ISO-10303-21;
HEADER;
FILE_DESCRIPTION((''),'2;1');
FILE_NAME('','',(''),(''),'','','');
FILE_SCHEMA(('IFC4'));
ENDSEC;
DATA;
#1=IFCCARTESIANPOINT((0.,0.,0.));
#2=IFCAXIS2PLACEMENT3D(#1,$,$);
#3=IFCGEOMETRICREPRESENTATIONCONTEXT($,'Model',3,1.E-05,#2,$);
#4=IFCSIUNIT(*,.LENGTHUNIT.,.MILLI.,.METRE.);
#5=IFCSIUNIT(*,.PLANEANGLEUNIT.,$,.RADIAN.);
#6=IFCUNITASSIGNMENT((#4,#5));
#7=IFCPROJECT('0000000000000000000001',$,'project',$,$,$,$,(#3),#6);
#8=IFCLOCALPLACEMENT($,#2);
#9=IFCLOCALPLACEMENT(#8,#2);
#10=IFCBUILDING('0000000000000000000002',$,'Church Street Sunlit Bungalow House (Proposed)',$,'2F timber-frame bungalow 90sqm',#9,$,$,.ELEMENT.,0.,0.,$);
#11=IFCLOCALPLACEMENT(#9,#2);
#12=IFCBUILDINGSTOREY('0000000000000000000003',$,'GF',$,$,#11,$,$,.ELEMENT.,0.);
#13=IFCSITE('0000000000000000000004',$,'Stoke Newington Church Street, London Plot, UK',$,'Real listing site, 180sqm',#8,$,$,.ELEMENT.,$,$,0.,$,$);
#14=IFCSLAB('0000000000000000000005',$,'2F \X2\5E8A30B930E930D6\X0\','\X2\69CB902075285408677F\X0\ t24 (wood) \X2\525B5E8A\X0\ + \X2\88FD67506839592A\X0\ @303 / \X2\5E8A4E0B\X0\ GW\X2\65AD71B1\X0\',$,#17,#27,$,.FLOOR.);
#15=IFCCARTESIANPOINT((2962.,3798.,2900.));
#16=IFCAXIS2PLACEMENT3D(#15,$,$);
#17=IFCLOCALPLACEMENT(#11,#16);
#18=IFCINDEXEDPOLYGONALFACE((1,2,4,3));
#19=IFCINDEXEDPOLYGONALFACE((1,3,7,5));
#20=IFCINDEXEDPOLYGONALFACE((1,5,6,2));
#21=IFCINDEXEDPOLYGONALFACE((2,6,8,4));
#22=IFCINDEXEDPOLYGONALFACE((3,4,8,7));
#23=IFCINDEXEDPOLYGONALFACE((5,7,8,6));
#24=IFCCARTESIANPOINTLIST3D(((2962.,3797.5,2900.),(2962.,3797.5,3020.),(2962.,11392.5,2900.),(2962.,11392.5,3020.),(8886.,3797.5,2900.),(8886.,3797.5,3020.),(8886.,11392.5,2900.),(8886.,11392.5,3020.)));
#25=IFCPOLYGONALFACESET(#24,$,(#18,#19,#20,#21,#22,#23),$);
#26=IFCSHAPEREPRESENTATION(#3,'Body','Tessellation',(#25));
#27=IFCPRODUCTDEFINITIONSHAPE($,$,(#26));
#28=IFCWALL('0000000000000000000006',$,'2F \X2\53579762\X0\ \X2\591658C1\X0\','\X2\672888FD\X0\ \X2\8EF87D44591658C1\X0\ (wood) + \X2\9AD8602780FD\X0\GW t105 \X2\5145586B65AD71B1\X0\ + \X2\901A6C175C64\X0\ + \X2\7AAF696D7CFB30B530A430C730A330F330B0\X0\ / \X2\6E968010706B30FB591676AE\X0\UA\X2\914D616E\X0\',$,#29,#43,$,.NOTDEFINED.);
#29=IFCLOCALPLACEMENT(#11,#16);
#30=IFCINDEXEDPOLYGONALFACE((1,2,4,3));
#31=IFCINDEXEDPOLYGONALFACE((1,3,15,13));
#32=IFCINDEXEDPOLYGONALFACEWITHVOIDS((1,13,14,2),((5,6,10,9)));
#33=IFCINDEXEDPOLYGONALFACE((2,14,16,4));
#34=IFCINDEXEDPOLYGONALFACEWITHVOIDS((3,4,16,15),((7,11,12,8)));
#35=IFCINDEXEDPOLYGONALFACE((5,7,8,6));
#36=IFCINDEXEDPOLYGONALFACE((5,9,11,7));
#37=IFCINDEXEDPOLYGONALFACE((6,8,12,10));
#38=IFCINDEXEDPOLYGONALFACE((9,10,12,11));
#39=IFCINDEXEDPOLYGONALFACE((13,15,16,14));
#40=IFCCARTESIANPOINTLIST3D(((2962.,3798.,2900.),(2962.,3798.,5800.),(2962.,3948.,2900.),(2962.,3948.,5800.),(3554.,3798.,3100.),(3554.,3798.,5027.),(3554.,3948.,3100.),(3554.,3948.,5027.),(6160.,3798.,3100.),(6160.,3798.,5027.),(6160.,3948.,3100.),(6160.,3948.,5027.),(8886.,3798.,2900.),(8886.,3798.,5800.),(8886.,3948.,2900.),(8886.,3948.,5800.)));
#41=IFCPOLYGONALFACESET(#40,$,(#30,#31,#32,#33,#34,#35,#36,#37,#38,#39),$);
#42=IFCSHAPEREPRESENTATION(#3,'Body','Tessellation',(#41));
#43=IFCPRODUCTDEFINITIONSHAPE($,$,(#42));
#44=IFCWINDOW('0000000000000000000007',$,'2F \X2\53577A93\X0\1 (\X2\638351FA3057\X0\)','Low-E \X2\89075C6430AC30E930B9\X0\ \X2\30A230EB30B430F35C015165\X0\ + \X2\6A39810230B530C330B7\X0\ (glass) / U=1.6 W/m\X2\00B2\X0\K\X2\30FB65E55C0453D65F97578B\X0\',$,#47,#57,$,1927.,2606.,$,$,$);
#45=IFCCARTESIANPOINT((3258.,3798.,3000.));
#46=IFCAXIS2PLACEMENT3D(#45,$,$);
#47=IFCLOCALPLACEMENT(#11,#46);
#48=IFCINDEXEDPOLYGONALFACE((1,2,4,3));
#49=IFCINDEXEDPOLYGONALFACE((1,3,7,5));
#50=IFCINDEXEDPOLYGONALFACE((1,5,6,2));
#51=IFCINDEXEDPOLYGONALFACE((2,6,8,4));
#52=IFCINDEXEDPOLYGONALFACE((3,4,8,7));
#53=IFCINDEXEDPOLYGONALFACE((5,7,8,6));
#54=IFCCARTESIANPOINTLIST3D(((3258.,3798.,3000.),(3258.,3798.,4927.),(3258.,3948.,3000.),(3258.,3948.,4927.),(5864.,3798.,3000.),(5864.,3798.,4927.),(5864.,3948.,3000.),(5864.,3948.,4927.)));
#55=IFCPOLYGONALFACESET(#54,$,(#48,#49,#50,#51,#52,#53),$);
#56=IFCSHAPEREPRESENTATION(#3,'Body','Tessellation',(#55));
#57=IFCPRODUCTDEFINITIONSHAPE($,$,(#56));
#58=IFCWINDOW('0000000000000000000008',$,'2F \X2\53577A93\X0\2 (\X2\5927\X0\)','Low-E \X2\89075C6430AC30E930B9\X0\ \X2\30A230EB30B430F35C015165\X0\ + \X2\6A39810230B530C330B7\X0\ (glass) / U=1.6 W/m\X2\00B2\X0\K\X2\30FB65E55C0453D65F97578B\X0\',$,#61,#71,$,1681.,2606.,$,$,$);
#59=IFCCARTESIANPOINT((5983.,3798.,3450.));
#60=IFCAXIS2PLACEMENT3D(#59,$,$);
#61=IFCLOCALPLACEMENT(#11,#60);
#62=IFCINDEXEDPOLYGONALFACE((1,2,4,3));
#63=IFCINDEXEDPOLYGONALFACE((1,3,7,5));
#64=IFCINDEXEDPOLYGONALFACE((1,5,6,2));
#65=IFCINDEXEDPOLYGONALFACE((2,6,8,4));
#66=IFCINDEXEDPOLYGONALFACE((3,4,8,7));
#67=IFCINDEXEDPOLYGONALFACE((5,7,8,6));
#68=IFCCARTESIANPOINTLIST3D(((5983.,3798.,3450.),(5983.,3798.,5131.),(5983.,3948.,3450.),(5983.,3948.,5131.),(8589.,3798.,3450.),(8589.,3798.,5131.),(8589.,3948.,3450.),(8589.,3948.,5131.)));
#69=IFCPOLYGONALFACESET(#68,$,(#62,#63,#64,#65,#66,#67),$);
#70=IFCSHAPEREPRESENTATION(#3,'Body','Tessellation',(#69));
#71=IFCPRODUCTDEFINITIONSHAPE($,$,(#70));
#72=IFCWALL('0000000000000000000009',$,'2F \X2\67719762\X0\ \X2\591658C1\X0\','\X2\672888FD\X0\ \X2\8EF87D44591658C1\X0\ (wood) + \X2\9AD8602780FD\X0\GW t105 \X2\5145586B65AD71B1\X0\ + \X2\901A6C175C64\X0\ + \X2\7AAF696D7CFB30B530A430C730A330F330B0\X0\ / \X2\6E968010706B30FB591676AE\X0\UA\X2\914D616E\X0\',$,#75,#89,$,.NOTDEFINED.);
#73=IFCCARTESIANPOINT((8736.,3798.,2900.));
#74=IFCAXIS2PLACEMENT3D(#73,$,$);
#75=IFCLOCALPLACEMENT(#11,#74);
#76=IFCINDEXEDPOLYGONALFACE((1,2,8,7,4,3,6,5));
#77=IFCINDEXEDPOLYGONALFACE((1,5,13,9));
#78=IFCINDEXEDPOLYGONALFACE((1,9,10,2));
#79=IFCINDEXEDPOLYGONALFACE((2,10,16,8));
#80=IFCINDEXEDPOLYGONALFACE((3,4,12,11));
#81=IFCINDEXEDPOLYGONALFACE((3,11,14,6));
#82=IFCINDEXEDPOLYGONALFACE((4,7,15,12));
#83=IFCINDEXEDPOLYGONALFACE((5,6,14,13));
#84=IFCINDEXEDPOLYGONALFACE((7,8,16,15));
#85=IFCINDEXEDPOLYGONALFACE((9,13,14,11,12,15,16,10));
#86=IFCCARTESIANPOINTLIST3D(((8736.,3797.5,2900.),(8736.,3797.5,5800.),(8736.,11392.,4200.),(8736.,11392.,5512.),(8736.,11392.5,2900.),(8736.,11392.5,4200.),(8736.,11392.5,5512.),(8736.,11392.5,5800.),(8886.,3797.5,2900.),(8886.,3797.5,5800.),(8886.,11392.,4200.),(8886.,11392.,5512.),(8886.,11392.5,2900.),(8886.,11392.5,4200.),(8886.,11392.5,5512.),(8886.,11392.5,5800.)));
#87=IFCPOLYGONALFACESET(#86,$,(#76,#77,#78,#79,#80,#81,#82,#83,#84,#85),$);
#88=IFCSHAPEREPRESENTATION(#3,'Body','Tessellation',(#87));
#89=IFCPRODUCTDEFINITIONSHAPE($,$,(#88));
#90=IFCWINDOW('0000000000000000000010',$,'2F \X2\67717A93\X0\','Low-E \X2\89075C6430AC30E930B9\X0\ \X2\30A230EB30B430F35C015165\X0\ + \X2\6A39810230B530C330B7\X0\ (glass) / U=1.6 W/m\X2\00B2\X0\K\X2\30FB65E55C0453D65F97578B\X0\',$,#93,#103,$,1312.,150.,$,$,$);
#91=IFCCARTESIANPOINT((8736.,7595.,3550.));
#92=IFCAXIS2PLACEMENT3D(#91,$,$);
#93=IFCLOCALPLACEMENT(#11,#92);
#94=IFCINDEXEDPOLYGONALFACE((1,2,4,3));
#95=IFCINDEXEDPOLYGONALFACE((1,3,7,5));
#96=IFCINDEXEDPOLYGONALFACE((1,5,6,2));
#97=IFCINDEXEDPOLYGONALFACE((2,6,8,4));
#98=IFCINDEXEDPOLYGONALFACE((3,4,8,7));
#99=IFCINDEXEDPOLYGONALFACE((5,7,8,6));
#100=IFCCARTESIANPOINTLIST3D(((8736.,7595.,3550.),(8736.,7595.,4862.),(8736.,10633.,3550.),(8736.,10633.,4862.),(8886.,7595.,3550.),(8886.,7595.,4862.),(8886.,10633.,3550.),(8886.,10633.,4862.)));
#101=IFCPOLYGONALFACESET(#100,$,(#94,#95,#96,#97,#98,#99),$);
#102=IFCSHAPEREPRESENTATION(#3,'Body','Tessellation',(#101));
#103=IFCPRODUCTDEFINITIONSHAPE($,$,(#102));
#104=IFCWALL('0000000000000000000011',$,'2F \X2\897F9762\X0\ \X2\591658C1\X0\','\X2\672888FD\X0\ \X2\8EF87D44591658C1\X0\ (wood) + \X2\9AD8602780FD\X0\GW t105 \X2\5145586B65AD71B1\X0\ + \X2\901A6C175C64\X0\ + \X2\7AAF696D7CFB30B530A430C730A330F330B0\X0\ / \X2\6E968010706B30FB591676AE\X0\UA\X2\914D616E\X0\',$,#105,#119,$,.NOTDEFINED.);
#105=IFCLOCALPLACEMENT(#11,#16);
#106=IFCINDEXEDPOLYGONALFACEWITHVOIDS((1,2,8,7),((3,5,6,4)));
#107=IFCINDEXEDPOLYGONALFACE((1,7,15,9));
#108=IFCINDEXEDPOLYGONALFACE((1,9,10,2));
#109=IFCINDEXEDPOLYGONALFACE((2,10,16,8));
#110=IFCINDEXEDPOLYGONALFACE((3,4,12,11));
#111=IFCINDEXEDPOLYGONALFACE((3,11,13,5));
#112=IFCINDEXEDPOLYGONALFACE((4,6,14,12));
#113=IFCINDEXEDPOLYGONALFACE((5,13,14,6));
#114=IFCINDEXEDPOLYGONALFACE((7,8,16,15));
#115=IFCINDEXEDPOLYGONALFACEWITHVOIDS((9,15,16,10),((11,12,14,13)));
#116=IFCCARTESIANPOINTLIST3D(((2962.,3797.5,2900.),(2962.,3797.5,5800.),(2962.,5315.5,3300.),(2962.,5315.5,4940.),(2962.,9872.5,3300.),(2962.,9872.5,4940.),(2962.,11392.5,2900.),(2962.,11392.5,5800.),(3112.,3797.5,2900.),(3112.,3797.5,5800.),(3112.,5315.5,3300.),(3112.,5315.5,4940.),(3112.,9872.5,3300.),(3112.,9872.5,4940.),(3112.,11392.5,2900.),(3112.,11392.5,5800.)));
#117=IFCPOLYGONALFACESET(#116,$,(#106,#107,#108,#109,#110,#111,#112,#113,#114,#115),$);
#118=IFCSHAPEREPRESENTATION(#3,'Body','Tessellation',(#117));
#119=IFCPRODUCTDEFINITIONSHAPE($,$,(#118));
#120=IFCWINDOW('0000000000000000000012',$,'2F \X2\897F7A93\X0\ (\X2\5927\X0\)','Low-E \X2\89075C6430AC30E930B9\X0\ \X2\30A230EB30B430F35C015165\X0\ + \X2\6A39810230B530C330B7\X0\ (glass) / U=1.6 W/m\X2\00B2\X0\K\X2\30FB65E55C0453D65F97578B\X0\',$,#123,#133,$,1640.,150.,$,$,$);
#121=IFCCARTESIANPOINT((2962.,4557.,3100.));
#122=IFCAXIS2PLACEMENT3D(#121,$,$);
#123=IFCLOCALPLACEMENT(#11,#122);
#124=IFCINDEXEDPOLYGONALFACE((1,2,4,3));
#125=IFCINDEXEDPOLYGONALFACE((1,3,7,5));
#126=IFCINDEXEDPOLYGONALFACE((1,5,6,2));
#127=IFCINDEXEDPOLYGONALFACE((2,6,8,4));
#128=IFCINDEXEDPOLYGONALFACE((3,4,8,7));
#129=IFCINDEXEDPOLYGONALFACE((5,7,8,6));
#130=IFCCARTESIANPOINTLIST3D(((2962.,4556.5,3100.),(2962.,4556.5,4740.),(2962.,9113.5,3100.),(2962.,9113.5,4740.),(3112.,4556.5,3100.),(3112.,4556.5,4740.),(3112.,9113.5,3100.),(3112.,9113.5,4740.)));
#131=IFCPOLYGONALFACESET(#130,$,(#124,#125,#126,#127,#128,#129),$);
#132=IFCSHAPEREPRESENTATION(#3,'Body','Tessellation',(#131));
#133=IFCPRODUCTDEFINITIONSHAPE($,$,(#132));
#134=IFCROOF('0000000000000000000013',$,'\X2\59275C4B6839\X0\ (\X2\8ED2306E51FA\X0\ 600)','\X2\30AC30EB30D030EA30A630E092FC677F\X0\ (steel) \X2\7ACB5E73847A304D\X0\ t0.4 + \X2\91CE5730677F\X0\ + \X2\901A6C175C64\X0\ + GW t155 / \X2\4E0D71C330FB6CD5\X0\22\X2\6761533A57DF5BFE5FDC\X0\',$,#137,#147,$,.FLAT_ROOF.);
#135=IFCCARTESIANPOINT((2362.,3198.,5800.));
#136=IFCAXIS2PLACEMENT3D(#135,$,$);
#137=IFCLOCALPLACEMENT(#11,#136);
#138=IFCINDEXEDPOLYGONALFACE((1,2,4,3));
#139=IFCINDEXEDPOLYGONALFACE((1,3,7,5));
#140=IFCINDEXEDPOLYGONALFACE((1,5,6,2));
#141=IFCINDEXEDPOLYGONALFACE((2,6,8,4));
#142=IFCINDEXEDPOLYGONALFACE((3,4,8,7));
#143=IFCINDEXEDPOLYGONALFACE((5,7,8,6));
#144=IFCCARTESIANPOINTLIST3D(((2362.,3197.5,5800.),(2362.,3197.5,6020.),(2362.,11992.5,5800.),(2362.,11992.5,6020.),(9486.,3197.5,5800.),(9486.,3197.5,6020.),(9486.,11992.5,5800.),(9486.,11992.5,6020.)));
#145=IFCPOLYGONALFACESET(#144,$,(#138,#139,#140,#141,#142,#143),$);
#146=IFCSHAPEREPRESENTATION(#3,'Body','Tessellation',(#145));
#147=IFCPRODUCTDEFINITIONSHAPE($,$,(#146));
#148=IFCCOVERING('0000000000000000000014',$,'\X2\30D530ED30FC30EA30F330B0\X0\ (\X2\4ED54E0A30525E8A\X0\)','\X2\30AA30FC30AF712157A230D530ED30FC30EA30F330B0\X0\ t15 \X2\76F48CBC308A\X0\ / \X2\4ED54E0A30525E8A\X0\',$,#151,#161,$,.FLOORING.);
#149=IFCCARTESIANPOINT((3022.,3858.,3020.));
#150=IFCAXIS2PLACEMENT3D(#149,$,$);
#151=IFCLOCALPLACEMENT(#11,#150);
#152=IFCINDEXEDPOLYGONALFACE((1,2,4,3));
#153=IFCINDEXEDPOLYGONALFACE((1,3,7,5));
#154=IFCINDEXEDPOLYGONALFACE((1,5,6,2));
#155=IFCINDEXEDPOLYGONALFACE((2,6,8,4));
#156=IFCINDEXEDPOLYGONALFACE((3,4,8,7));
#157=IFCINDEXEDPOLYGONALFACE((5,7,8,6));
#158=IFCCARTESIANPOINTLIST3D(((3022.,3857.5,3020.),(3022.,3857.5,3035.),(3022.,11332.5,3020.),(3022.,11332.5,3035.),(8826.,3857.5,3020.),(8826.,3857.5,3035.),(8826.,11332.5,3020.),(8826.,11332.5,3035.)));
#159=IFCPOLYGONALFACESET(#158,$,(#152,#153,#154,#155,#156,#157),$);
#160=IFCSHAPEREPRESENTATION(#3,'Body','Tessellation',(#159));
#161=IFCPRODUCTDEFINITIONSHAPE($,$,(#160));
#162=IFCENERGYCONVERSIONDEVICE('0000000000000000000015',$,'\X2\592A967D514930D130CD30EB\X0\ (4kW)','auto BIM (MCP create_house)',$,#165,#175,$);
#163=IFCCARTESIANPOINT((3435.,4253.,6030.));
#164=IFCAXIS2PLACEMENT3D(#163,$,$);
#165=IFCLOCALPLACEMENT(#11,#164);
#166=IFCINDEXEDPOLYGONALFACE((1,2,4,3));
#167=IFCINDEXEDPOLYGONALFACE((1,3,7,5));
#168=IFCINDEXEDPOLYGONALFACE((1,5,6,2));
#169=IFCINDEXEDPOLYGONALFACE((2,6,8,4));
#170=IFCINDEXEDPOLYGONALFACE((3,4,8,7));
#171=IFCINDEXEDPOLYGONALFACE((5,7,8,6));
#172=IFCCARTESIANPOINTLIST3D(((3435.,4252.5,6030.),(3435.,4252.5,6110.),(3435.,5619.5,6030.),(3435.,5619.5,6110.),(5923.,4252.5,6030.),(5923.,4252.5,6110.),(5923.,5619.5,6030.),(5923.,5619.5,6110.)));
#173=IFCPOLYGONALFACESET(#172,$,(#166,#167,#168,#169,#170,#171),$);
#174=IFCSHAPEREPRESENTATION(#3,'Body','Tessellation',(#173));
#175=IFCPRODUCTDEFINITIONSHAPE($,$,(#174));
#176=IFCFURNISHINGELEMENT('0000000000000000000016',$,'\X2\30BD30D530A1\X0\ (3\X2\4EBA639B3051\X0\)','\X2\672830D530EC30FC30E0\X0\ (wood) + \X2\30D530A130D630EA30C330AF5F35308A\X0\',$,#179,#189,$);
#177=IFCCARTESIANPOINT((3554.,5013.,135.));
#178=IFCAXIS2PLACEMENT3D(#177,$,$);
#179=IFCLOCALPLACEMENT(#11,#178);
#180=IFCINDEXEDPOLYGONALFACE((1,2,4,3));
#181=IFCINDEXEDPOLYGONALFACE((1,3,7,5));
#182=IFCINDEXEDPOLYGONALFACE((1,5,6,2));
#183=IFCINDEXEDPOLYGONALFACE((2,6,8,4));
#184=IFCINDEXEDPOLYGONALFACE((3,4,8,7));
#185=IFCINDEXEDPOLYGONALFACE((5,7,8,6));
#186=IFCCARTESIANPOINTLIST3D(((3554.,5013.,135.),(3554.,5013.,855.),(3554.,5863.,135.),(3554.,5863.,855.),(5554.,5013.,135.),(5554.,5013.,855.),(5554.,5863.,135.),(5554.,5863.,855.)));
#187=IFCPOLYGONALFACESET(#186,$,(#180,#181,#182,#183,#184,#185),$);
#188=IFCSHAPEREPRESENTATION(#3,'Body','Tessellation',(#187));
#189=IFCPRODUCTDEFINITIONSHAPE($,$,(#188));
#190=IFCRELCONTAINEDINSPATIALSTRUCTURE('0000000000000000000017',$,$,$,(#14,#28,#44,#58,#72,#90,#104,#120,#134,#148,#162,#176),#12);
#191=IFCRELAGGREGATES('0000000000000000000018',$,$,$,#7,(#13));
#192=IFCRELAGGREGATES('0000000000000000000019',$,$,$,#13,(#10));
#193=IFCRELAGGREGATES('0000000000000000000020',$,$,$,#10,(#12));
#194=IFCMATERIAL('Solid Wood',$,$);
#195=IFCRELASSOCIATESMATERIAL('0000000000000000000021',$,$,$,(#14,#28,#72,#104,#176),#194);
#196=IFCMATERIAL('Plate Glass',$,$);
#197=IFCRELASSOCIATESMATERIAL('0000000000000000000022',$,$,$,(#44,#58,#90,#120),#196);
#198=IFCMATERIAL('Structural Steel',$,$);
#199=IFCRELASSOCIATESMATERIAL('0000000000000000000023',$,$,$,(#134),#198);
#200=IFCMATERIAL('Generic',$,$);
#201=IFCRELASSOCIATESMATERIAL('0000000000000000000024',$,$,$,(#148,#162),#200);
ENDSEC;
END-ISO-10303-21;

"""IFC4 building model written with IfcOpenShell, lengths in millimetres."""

from ifc_helpers import new_model, si_unit, frame, frame_2d, origin, place, context, project, spatial, rectangle, extrude, material, element, fill, save


model = new_model("IFC4")

# Units and contexts
model_context = context("Model", 3, precision=1e-05, world=origin())
ifc_project = project(units=[si_unit("LENGTHUNIT", "METRE", prefix="MILLI"), si_unit("PLANEANGLEUNIT", "RADIAN")], contexts=[model_context])

# Site, building, storey
site_placement = place(None, origin())
site = spatial("IfcSite", under=ifc_project, at=site_placement, Name="Stoke Newington Church Street, London Plot, UK", ObjectType="Real listing site, 180sqm", CompositionType="ELEMENT", RefElevation=0.0)
building_placement = place(site_placement, origin())
building = spatial("IfcBuilding", under=site, at=building_placement, Name="Church Street Sunlit Bungalow House (Proposed)", ObjectType="2F timber-frame bungalow 90sqm", CompositionType="ELEMENT", ElevationOfRefHeight=0.0, ElevationOfTerrain=0.0)
storey_placement = place(building_placement, origin())
storey = spatial("IfcBuildingStorey", under=building, at=storey_placement, Name="GF", CompositionType="ELEMENT", Elevation=0.0)

# Slab
ifc_material_1 = material(Name="Solid Wood")
slab_placement = place(storey_placement, frame((2962.0, 3798.0, 2900.0)))
element("IfcSlab", 1, at=slab_placement, inside=storey, material=ifc_material_1, Name="2F 床スラブ", Description="構造用合板 t24 (wood) 剛床 + 製材根太 @303 / 床下 GW断熱", PredefinedType="FLOOR", context=model_context, shape_type="SweptSolid", body=[
    extrude(rectangle(XDim=5924.0, YDim=7595.0, at=frame_2d((2962.0, 3797.0))), frame((2962.0, 3798.0, 2900.0)), (0.0, 0.0, 1.0), 120.0),
])

# Wall, openings, windows
wall_1_placement = place(storey_placement, frame((2962.0, 3798.0, 2900.0)))
wall_1 = element("IfcWall", 2, at=wall_1_placement, inside=storey, material=ifc_material_1, Name="2F 南面 外壁", Description="木製 軸組外壁 (wood) + 高性能GW t105 充填断熱 + 通気層 + 窯業系サイディング / 準耐火・外皮UA配慮", PredefinedType="NOTDEFINED", context=model_context, shape_type="SweptSolid", body=[
    extrude(rectangle(XDim=5924.0, YDim=150.0, at=frame_2d((2962.0, 75.0))), frame((2962.0, 3798.0, 2900.0)), (0.0, 0.0, 1.0), 2900.0),
])
opening_1_placement = place(storey_placement, frame((3258.0, 3798.0, 3000.0)))
opening_1 = element("IfcOpeningElement", 3, at=opening_1_placement, cuts=wall_1, PredefinedType="NOTDEFINED", context=model_context, shape_type="SweptSolid", body=[
    extrude(rectangle(XDim=2606.0, YDim=150.0, at=frame_2d((1303.0, 75.0))), frame((3258.0, 3798.0, 3000.0)), (0.0, 0.0, 1.0), 1927.0),
])
opening_2_placement = place(storey_placement, frame((5983.0, 3798.0, 3450.0)))
opening_2 = element("IfcOpeningElement", 4, at=opening_2_placement, cuts=wall_1, PredefinedType="NOTDEFINED", context=model_context, shape_type="SweptSolid", body=[
    extrude(rectangle(XDim=2606.0, YDim=150.0, at=frame_2d((1303.0, 75.0))), frame((5983.0, 3798.0, 3450.0)), (0.0, 0.0, 1.0), 1681.0),
])
ifc_material_2 = material(Name="Plate Glass")
window_1_placement = place(storey_placement, frame((3258.0, 3798.0, 3000.0)))
window_1 = element("IfcWindow", 5, at=window_1_placement, inside=storey, material=ifc_material_2, Name="2F 南窓1 (掃出し)", Description="Low-E 複層ガラス アルゴン封入 + 樹脂サッシ (glass) / U=1.6 W/m²K・日射取得型", OverallHeight=1927.0, OverallWidth=2606.0, context=model_context, shape_type="SweptSolid", body=[
    extrude(rectangle(XDim=2606.0, YDim=150.0, at=frame_2d((1303.0, 75.0))), frame((3258.0, 3798.0, 3000.0)), (0.0, 0.0, 1.0), 1927.0),
])
fill(opening_1, window_1)
window_2_placement = place(storey_placement, frame((5983.0, 3798.0, 3450.0)))
window_2 = element("IfcWindow", 6, at=window_2_placement, inside=storey, material=ifc_material_2, Name="2F 南窓2 (大)", Description="Low-E 複層ガラス アルゴン封入 + 樹脂サッシ (glass) / U=1.6 W/m²K・日射取得型", OverallHeight=1681.0, OverallWidth=2606.0, context=model_context, shape_type="SweptSolid", body=[
    extrude(rectangle(XDim=2606.0, YDim=150.0, at=frame_2d((1303.0, 75.0))), frame((5983.0, 3798.0, 3450.0)), (0.0, 0.0, 1.0), 1681.0),
])
fill(opening_2, window_2)

# Walls, openings, windows
wall_2_placement = place(storey_placement, frame((8736.0, 3798.0, 2900.0)))
wall_2 = element("IfcWall", 7, at=wall_2_placement, inside=storey, material=ifc_material_1, Name="2F 東面 外壁", Description="木製 軸組外壁 (wood) + 高性能GW t105 充填断熱 + 通気層 + 窯業系サイディング / 準耐火・外皮UA配慮", PredefinedType="NOTDEFINED", context=model_context, shape_type="SweptSolid", body=[
    extrude(rectangle(XDim=150.0, YDim=7595.0, at=frame_2d((75.0, 3797.0))), frame((8736.0, 3798.0, 2900.0)), (0.0, 0.0, 1.0), 2900.0),
])
opening_3_placement = place(storey_placement, frame((8736.0, 7595.0, 3550.0)))
opening_3 = element("IfcOpeningElement", 8, at=opening_3_placement, cuts=wall_2, PredefinedType="NOTDEFINED", context=model_context, shape_type="SweptSolid", body=[
    extrude(rectangle(XDim=150.0, YDim=3038.0, at=frame_2d((75.0, 1519.0))), frame((8736.0, 7595.0, 3550.0)), (0.0, 0.0, 1.0), 1312.0),
])
window_3_placement = place(storey_placement, frame((8736.0, 7595.0, 3550.0)))
window_3 = element("IfcWindow", 9, at=window_3_placement, inside=storey, material=ifc_material_2, Name="2F 東窓", Description="Low-E 複層ガラス アルゴン封入 + 樹脂サッシ (glass) / U=1.6 W/m²K・日射取得型", OverallHeight=1312.0, OverallWidth=150.0, context=model_context, shape_type="SweptSolid", body=[
    extrude(rectangle(XDim=150.0, YDim=3038.0, at=frame_2d((75.0, 1519.0))), frame((8736.0, 7595.0, 3550.0)), (0.0, 0.0, 1.0), 1312.0),
])
fill(opening_3, window_3)
wall_3_placement = place(storey_placement, frame((2962.0, 3798.0, 2900.0)))
wall_3 = element("IfcWall", 10, at=wall_3_placement, inside=storey, material=ifc_material_1, Name="2F 西面 外壁", Description="木製 軸組外壁 (wood) + 高性能GW t105 充填断熱 + 通気層 + 窯業系サイディング / 準耐火・外皮UA配慮", PredefinedType="NOTDEFINED", context=model_context, shape_type="SweptSolid", body=[
    extrude(rectangle(XDim=150.0, YDim=7595.0, at=frame_2d((75.0, 3797.0))), frame((2962.0, 3798.0, 2900.0)), (0.0, 0.0, 1.0), 2900.0),
])
opening_4_placement = place(storey_placement, frame((2962.0, 4557.0, 3100.0)))
opening_4 = element("IfcOpeningElement", 11, at=opening_4_placement, cuts=wall_3, PredefinedType="NOTDEFINED", context=model_context, shape_type="SweptSolid", body=[
    extrude(rectangle(XDim=150.0, YDim=4557.0, at=frame_2d((75.0, 2278.0))), frame((2962.0, 4557.0, 3100.0)), (0.0, 0.0, 1.0), 1640.0),
])
window_4_placement = place(storey_placement, frame((2962.0, 4557.0, 3100.0)))
window_4 = element("IfcWindow", 12, at=window_4_placement, inside=storey, material=ifc_material_2, Name="2F 西窓 (大)", Description="Low-E 複層ガラス アルゴン封入 + 樹脂サッシ (glass) / U=1.6 W/m²K・日射取得型", OverallHeight=1640.0, OverallWidth=150.0, context=model_context, shape_type="SweptSolid", body=[
    extrude(rectangle(XDim=150.0, YDim=4557.0, at=frame_2d((75.0, 2278.0))), frame((2962.0, 4557.0, 3100.0)), (0.0, 0.0, 1.0), 1640.0),
])
fill(opening_4, window_4)

# Roof
ifc_material_3 = material(Name="Structural Steel")
roof_placement = place(storey_placement, frame((2362.0, 3198.0, 5800.0)))
element("IfcRoof", 13, at=roof_placement, inside=storey, material=ifc_material_3, Name="大屋根 (軒の出 600)", Description="ガルバリウム鋼板 (steel) 立平葺き t0.4 + 野地板 + 通気層 + GW t155 / 不燃・法22条区域対応", PredefinedType="FLAT_ROOF", context=model_context, shape_type="SweptSolid", body=[
    extrude(rectangle(XDim=7124.0, YDim=8795.0, at=frame_2d((3562.0, 4397.0))), frame((2362.0, 3198.0, 5800.0)), (0.0, 0.0, 1.0), 220.0),
])

# Covering
ifc_material_4 = material(Name="Generic")
covering_placement = place(storey_placement, frame((3022.0, 3858.0, 3020.0)))
element("IfcCovering", 14, at=covering_placement, inside=storey, material=ifc_material_4, Name="フローリング (仕上げ床)", Description="オーク無垢フローリング t15 直貼り / 仕上げ床", PredefinedType="FLOORING", context=model_context, shape_type="SweptSolid", body=[
    extrude(rectangle(XDim=5804.0, YDim=7475.0, at=frame_2d((2902.0, 3737.0))), frame((3022.0, 3858.0, 3020.0)), (0.0, 0.0, 1.0), 15.0),
])

# Energy conversion device
energy_conversion_device_placement = place(storey_placement, frame((3435.0, 4253.0, 6030.0)))
element("IfcEnergyConversionDevice", 15, at=energy_conversion_device_placement, inside=storey, material=ifc_material_4, Name="太陽光パネル (4kW)", Description="auto BIM (MCP create_house)", context=model_context, shape_type="SweptSolid", body=[
    extrude(rectangle(XDim=2488.0, YDim=1367.0, at=frame_2d((1244.0, 683.0))), frame((3435.0, 4253.0, 6030.0)), (0.0, 0.0, 1.0), 80.0),
])

# Furnishing element
furnishing_1_placement = place(storey_placement, frame((3554.0, 5013.0, 135.0)))
element("IfcFurnishingElement", 16, at=furnishing_1_placement, inside=storey, material=ifc_material_1, Name="ソファ (3人掛け)", Description="木フレーム (wood) + ファブリック張り", context=model_context, shape_type="SweptSolid", body=[
    extrude(rectangle(XDim=2000.0, YDim=850.0, at=frame_2d((1000.0, 425.0))), frame((3554.0, 5013.0, 135.0)), (0.0, 0.0, 1.0), 720.0),
])

save(model, "model.ifc")
